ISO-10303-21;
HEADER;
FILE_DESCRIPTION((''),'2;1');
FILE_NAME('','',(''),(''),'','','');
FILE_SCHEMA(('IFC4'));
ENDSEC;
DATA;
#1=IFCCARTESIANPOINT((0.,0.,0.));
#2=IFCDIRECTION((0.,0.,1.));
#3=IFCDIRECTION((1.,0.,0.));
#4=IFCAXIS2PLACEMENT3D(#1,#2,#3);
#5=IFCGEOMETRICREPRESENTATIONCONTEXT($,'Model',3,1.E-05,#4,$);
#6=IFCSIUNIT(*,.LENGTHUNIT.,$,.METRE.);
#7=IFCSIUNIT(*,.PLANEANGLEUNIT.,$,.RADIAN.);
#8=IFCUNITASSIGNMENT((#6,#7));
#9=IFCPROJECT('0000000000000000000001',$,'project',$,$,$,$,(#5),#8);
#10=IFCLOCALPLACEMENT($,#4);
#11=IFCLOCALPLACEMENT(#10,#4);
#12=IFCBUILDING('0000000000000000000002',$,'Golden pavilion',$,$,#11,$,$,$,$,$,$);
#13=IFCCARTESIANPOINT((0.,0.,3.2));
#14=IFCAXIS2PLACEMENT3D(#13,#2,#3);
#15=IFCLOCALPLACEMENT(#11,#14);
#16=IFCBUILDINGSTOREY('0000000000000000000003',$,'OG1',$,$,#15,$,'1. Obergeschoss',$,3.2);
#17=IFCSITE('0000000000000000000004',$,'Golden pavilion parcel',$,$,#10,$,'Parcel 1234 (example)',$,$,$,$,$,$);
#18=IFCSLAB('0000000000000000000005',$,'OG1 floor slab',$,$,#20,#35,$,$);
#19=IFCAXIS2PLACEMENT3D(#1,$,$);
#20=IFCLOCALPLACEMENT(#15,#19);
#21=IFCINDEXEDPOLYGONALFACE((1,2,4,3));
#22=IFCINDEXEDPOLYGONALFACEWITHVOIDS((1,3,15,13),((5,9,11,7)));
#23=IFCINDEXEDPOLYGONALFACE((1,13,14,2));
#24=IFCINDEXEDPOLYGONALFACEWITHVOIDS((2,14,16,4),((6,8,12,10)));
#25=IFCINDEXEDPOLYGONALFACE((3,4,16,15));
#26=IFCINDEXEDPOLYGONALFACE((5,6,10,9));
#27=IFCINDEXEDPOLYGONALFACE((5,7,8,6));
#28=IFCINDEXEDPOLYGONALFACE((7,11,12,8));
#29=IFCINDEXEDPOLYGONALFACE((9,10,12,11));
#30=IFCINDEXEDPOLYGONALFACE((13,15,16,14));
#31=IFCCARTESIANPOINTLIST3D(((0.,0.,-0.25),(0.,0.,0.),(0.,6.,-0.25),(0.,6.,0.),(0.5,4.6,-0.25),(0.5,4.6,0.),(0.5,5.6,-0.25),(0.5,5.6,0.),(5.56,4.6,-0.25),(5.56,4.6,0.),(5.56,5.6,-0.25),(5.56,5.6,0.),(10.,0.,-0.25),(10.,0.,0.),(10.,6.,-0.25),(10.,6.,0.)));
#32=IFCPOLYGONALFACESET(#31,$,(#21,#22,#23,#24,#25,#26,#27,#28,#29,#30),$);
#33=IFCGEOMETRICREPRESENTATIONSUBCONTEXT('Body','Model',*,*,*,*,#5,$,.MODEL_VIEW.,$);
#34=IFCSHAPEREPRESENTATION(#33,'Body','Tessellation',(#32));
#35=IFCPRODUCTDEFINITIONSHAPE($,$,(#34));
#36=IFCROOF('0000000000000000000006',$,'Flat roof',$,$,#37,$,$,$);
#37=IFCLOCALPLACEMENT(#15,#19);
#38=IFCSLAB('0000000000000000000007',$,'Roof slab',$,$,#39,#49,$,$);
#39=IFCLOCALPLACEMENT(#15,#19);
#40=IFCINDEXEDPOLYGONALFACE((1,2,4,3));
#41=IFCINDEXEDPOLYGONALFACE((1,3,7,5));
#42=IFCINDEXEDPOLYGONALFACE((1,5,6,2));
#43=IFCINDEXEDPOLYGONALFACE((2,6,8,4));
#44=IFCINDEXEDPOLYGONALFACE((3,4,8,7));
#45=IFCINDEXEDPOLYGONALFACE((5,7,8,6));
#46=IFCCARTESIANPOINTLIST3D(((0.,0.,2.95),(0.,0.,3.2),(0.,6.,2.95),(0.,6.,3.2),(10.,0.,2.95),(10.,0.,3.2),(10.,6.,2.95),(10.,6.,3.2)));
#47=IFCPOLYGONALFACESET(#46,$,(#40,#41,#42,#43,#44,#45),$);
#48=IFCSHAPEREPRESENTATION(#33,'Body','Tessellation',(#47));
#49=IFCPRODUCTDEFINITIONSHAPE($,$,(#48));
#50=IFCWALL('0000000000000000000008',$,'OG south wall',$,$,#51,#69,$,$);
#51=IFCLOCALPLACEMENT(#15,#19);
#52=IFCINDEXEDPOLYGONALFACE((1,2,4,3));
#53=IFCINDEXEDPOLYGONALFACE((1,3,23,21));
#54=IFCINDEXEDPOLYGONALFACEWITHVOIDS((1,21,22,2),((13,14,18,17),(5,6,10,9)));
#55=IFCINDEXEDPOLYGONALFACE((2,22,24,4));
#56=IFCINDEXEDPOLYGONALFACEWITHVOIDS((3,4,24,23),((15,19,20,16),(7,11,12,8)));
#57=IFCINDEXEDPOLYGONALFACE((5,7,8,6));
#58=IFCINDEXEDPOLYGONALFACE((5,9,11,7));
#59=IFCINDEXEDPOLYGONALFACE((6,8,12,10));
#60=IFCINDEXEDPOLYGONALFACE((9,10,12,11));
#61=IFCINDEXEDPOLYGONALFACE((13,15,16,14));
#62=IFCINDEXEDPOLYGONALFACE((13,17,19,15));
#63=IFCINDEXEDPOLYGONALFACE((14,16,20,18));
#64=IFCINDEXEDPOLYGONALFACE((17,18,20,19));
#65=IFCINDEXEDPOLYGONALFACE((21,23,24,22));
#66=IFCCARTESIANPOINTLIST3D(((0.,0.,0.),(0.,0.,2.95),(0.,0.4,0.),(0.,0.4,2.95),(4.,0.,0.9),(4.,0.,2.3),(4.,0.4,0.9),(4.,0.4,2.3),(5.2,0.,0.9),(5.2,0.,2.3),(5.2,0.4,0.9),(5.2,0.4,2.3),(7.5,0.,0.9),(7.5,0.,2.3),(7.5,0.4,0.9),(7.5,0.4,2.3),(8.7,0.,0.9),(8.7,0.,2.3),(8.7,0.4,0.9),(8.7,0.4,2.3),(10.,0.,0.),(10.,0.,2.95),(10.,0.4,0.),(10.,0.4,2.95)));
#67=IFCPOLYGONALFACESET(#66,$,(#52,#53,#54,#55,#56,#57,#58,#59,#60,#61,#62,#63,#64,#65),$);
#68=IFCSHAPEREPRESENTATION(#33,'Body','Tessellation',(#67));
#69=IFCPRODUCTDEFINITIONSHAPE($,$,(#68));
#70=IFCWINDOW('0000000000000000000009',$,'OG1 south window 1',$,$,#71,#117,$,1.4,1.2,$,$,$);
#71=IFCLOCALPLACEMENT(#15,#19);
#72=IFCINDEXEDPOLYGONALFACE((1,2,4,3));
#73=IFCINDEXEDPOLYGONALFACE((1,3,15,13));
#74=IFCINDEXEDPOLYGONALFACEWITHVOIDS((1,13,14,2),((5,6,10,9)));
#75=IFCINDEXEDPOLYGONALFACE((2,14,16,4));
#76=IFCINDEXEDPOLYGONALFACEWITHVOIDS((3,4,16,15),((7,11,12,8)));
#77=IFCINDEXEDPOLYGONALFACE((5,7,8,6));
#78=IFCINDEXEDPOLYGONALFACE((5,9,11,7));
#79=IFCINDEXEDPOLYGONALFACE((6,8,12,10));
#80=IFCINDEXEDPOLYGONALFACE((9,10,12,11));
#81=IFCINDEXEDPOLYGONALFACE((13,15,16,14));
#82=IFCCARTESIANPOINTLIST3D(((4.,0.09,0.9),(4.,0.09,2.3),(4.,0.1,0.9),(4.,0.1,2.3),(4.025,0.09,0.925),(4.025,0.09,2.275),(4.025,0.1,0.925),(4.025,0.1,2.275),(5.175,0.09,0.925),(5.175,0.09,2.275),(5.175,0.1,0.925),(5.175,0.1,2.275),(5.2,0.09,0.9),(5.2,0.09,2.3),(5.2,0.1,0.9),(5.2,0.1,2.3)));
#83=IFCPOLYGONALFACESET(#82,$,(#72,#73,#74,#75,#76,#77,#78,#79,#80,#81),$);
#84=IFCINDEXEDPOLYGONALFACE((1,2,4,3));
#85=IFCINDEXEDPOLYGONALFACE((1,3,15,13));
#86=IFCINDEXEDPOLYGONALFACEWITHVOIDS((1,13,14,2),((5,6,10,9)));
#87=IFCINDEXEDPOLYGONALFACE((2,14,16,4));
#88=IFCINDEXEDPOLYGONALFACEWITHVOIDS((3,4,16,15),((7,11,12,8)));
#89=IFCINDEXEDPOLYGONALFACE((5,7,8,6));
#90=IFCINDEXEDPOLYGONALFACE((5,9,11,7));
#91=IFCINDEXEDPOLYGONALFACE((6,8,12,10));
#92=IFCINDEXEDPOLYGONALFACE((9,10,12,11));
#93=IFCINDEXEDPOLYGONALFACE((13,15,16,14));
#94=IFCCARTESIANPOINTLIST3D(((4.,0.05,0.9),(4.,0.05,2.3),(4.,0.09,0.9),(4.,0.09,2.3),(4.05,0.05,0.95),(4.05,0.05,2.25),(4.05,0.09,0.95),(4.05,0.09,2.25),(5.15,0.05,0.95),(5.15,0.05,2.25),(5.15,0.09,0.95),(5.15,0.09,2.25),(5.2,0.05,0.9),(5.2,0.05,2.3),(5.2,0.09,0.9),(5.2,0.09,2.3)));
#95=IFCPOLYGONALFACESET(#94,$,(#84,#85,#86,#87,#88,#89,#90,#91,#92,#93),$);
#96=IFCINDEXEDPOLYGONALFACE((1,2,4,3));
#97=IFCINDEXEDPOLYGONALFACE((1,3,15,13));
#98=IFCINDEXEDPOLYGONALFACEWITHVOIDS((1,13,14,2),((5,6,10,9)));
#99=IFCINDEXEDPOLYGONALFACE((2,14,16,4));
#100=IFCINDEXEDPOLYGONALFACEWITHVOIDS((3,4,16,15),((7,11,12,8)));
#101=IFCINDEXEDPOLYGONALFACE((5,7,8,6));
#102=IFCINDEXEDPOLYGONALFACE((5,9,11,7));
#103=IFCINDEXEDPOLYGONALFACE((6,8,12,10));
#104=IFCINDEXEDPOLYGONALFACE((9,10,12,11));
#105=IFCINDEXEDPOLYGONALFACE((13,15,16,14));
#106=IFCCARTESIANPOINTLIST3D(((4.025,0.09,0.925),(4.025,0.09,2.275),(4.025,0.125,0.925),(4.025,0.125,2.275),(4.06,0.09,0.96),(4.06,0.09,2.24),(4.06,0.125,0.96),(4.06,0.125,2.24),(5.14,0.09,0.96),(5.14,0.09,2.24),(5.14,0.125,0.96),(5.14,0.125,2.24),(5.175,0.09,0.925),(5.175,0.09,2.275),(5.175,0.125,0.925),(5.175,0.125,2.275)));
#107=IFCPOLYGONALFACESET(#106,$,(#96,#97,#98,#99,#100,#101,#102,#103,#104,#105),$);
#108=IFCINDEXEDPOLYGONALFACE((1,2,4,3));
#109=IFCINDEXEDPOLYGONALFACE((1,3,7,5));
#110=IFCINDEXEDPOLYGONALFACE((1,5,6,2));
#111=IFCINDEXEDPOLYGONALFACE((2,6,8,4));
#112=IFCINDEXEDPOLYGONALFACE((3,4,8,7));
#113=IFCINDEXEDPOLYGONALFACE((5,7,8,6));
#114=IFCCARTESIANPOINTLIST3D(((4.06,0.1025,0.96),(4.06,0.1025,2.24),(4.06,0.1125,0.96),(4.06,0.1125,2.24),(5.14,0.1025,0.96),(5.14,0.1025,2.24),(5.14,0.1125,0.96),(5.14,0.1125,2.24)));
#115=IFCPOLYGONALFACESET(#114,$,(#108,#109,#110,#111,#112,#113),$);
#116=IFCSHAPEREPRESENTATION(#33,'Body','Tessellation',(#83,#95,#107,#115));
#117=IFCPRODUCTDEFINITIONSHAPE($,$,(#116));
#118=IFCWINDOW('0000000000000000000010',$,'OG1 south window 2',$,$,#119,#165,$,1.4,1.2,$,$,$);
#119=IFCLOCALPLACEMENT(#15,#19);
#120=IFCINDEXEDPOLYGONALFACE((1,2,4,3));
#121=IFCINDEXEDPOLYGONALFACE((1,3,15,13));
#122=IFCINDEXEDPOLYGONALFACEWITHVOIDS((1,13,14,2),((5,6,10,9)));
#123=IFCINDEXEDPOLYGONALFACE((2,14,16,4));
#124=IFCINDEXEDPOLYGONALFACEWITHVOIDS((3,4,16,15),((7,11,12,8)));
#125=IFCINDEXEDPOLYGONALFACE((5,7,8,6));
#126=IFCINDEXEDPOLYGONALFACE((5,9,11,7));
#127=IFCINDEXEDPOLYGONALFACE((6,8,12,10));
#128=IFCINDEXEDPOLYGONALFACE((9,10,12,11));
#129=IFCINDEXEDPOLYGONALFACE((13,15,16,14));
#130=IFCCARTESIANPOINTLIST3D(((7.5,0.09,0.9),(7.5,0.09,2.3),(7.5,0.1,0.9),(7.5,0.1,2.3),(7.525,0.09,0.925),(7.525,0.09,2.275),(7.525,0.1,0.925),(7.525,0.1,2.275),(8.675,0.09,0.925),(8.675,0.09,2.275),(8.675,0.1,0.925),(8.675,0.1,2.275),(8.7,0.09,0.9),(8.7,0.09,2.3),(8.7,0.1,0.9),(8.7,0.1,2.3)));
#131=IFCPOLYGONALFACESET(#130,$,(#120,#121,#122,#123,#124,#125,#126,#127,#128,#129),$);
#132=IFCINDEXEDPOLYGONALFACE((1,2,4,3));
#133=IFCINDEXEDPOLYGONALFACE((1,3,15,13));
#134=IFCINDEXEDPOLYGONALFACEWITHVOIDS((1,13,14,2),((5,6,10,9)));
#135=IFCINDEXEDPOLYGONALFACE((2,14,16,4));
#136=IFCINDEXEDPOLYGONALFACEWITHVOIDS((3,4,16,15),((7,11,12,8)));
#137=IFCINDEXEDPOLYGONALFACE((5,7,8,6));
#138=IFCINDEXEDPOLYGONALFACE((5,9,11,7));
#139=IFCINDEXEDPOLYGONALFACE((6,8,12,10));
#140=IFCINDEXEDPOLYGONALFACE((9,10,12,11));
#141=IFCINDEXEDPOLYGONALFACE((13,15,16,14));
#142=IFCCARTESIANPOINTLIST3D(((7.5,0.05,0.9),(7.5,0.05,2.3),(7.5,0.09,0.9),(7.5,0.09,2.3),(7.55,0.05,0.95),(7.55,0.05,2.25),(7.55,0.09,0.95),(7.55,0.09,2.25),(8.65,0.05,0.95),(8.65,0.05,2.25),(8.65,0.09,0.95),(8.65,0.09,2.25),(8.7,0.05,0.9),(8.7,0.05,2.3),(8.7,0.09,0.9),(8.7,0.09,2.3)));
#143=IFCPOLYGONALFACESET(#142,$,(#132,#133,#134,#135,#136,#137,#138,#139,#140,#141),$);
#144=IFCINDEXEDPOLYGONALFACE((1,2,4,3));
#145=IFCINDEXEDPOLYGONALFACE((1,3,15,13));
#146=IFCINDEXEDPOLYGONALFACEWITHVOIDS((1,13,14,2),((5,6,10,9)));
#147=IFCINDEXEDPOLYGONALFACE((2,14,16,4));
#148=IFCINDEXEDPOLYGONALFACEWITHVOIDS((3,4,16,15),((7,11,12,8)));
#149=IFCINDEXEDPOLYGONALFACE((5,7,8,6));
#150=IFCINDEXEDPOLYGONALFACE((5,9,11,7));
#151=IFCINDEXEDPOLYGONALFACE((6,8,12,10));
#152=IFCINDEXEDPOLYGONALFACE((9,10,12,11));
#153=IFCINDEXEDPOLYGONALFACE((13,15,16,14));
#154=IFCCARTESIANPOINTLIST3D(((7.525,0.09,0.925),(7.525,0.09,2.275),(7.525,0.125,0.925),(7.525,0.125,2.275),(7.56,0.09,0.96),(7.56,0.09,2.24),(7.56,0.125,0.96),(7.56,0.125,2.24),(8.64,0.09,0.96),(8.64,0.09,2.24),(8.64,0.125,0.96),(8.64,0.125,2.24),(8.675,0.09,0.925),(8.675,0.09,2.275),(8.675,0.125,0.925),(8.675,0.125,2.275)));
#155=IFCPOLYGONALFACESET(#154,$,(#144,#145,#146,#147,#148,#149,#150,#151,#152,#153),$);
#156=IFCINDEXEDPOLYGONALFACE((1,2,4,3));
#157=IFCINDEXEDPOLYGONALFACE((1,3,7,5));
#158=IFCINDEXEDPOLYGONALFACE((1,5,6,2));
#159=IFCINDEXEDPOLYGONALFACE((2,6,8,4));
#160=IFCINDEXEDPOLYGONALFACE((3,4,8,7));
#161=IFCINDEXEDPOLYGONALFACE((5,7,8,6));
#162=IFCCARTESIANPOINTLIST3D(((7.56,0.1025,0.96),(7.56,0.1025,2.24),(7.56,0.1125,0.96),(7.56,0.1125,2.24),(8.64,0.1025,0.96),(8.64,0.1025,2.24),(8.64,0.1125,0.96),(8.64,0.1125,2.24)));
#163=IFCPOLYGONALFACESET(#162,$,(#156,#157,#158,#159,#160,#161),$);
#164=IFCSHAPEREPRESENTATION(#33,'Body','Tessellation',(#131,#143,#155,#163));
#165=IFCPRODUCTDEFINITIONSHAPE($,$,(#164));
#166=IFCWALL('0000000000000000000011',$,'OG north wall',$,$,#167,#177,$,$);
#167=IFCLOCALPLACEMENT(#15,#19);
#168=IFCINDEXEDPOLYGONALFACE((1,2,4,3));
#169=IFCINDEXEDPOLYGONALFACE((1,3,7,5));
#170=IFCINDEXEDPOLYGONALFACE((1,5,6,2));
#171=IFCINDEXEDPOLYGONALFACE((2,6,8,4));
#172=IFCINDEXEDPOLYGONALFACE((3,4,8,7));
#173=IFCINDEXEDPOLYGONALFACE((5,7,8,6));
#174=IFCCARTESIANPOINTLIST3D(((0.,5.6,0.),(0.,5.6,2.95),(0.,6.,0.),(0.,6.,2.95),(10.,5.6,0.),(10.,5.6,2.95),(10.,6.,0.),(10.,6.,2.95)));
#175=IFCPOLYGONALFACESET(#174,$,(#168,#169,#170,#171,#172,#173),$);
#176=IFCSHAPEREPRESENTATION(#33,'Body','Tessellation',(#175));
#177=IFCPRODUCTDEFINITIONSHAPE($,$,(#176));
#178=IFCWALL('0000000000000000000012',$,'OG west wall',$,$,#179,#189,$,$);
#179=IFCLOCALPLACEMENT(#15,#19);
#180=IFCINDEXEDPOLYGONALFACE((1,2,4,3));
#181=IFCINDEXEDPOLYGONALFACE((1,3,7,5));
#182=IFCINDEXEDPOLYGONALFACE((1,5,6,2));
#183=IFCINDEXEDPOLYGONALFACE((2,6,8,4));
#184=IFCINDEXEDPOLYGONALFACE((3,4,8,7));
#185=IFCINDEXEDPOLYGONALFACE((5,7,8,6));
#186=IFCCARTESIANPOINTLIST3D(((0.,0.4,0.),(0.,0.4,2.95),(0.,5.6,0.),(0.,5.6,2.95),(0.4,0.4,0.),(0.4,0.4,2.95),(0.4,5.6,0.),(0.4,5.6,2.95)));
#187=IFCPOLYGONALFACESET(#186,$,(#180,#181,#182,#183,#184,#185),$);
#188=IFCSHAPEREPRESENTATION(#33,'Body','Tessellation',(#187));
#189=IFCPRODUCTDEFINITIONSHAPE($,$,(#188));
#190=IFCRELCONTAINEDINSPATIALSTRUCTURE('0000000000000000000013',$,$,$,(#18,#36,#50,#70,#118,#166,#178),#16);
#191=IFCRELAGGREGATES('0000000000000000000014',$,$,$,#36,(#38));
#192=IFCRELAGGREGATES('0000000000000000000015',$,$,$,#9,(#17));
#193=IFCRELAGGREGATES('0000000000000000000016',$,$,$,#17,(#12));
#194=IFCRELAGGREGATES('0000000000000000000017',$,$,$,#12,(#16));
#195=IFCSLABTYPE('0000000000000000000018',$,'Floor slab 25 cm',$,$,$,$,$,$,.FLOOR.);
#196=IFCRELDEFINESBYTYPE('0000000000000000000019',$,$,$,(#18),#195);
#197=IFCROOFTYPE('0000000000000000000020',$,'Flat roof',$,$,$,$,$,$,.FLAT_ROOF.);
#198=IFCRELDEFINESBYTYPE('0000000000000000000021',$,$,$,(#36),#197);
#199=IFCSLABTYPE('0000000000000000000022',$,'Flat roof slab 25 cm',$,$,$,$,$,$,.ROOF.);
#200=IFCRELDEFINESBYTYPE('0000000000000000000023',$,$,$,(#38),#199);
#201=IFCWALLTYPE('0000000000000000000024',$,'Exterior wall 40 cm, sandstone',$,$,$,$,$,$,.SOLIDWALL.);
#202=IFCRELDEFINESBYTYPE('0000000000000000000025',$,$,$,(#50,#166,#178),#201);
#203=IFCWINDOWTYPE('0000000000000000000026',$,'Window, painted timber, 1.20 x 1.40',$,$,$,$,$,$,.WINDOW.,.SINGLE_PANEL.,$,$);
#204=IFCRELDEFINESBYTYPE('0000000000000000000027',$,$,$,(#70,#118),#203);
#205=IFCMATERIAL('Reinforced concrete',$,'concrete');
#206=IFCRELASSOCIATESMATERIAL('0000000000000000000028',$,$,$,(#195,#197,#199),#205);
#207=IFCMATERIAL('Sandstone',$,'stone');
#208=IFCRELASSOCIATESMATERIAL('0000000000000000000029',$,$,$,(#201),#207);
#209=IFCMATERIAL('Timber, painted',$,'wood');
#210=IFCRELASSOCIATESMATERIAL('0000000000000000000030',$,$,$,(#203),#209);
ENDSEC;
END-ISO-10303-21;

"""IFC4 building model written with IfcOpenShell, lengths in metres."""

from ifc_helpers import new_model, si_unit, frame, origin_with_axes, place, context, subcontext, project, spatial, line, indexed_curve, outline, extrude, source, transform, mapped, material, type_object, type_shapes, element, fill, aggregate, save


model = new_model("IFC4")

# Units and contexts
model_context = context("Model", 3, precision=1e-05, world=origin_with_axes())
body_context = subcontext(model_context, "Body", "Model", "MODEL_VIEW")
ifc_project = project(units=[si_unit("LENGTHUNIT", "METRE"), si_unit("PLANEANGLEUNIT", "RADIAN")], contexts=[model_context])

# Site, building, storey
site_placement = place(None, origin_with_axes())
site = spatial("IfcSite", under=ifc_project, at=site_placement, Name="Golden pavilion parcel", LongName="Parcel 1234 (example)")
building_placement = place(site_placement, origin_with_axes())
building = spatial("IfcBuilding", under=site, at=building_placement, Name="Golden pavilion")
storey_placement = place(building_placement, frame((0.0, 0.0, 3.2), z_axis=(0.0, 0.0, 1.0), x_axis=(1.0, 0.0, 0.0)))
storey = spatial("IfcBuildingStorey", under=building, at=storey_placement, Name="OG1", LongName="1. Obergeschoss", Elevation=3.2)

# Slab
ifc_material_1 = material(Name="Reinforced concrete", Category="concrete")
slab_type_1 = type_object("IfcSlabType", Name="Floor slab 25 cm", PredefinedType="FLOOR", material=ifc_material_1)
slab_1_placement = place(storey_placement, frame((0.0, 0.0, -0.25), z_axis=(0.0, 0.0, 1.0), x_axis=(1.0, 0.0, 0.0)))
element("IfcSlab", 1, at=slab_1_placement, inside=storey, type_object=slab_type_1, Name="OG1 floor slab", context=body_context, shape_type="SweptSolid", body=[
    extrude(outline(indexed_curve([(0.0, 0.0), (10.0, 0.0), (10.0, 6.0), (0.0, 6.0)], segments=[line(1, 2, 3, 4, 1)]), holes=[indexed_curve([(0.5, 4.6), (5.56, 4.6), (5.56, 5.6), (0.5, 5.6)], segments=[line(1, 2, 3, 4, 1)])]), origin_with_axes(), (0.0, 0.0, 1.0), 0.25),
])

# Roof, slab
roof_type = type_object("IfcRoofType", Name="Flat roof", PredefinedType="FLAT_ROOF", material=ifc_material_1)
roof_placement = place(storey_placement, frame((0.0, 0.0, 2.95), z_axis=(0.0, 0.0, 1.0), x_axis=(1.0, 0.0, 0.0)))
roof = element("IfcRoof", 2, at=roof_placement, inside=storey, type_object=roof_type, Name="Flat roof")
slab_type_2 = type_object("IfcSlabType", Name="Flat roof slab 25 cm", PredefinedType="ROOF", material=ifc_material_1)
slab_2_placement = place(roof_placement, origin_with_axes())
slab_2 = element("IfcSlab", 3, at=slab_2_placement, type_object=slab_type_2, Name="Roof slab", context=body_context, shape_type="SweptSolid", body=[
    extrude(outline(indexed_curve([(0.0, 0.0), (10.0, 0.0), (10.0, 6.0), (0.0, 6.0)], segments=[line(1, 2, 3, 4, 1)])), origin_with_axes(), (0.0, 0.0, 1.0), 0.25),
])
aggregate(roof, [slab_2])

# Wall, openings, windows
ifc_material_2 = material(Name="Sandstone", Category="stone")
wall_type = type_object("IfcWallType", Name="Exterior wall 40 cm, sandstone", PredefinedType="SOLIDWALL", material=ifc_material_2)
wall_1_placement = place(storey_placement, origin_with_axes())
wall_1 = element("IfcWall", 4, at=wall_1_placement, inside=storey, type_object=wall_type, Name="OG south wall", context=body_context, shape_type="SweptSolid", body=[
    extrude(outline(indexed_curve([(0.0, 0.0), (0.0, 0.4), (10.0, 0.4), (10.0, 0.0), (0.0, 0.0)], self_intersect=False)), origin_with_axes(), (0.0, 0.0, 1.0), 2.95),
])
opening_1_placement = place(wall_1_placement, origin_with_axes())
opening_1 = element("IfcOpeningElement", 5, at=opening_1_placement, cuts=wall_1, PredefinedType="OPENING", context=body_context, shape_type="SweptSolid", body=[
    extrude(outline(indexed_curve([(4.0, -0.05), (5.2, -0.05), (5.2, 0.45), (4.0, 0.45)], segments=[line(1, 2, 3, 4, 1)])), frame((0.0, 0.0, 0.9), z_axis=(0.0, 0.0, 1.0), x_axis=(1.0, 0.0, 0.0)), (0.0, 0.0, 1.0), 1.4),
])
opening_2_placement = place(wall_1_placement, origin_with_axes())
opening_2 = element("IfcOpeningElement", 6, at=opening_2_placement, cuts=wall_1, PredefinedType="OPENING", context=body_context, shape_type="SweptSolid", body=[
    extrude(outline(indexed_curve([(7.5, -0.05), (8.7, -0.05), (8.7, 0.45), (7.5, 0.45)], segments=[line(1, 2, 3, 4, 1)])), frame((0.0, 0.0, 0.9), z_axis=(0.0, 0.0, 1.0), x_axis=(1.0, 0.0, 0.0)), (0.0, 0.0, 1.0), 1.4),
])
ifc_material_3 = material(Name="Timber, painted", Category="wood")
window_type = type_object("IfcWindowType", Name="Window, painted timber, 1.20 x 1.40", PartitioningType="SINGLE_PANEL", PredefinedType="WINDOW", material=ifc_material_3)
shared_shape = source(origin_with_axes(), body_context, "Body", "SweptSolid", [
    extrude(outline(indexed_curve([(0.0, 0.0), (1.2, 0.0), (1.2, 1.4), (0.0, 1.4)], segments=[line(1, 2, 3, 4, 1)]), holes=[indexed_curve([(0.025, 0.025), (1.175, 0.025), (1.175, 1.375), (0.025, 1.375)], segments=[line(1, 2, 3, 4, 1)])]), frame((0.0, 0.09, 0.0), z_axis=(0.0, -1.0, 0.0), x_axis=(1.0, 0.0, 0.0)), (0.0, 0.0, -1.0), 0.01),
    extrude(outline(indexed_curve([(0.0, 0.0), (1.2, 0.0), (1.2, 1.4), (0.0, 1.4)], segments=[line(1, 2, 3, 4, 1)]), holes=[indexed_curve([(0.05, 0.05), (1.15, 0.05), (1.15, 1.35), (0.05, 1.35)], segments=[line(1, 2, 3, 4, 1)])]), frame((0.0, 0.05, 0.0), z_axis=(0.0, -1.0, 0.0), x_axis=(1.0, 0.0, 0.0)), (0.0, 0.0, -1.0), 0.04),
    extrude(outline(indexed_curve([(0.0, 0.0), (1.15, 0.0), (1.15, 1.35), (0.0, 1.35)], segments=[line(1, 2, 3, 4, 1)]), holes=[indexed_curve([(0.035, 0.035), (1.115, 0.035), (1.115, 1.315), (0.035, 1.315)], segments=[line(1, 2, 3, 4, 1)])]), frame((0.025, 0.09, 0.025), z_axis=(0.0, -1.0, 0.0), x_axis=(1.0, 0.0, 0.0)), (0.0, 0.0, -1.0), 0.035),
    extrude(outline(indexed_curve([(0.035, 0.035), (1.115, 0.035), (1.115, 1.315), (0.035, 1.315)], segments=[line(1, 2, 3, 4, 1)])), frame((0.025, 0.1025, 0.025), z_axis=(0.0, -1.0, 0.0), x_axis=(1.0, 0.0, 0.0)), (0.0, 0.0, -1.0), 0.01),
])
type_shapes(window_type, [shared_shape])
window_1_placement = place(storey_placement, frame((4.0, 0.0, 0.9), z_axis=(0.0, 0.0, 1.0), x_axis=(1.0, 0.0, 0.0)))
window_1 = element("IfcWindow", 7, at=window_1_placement, inside=storey, type_object=window_type, Name="OG1 south window 1", OverallHeight=1.4, OverallWidth=1.2, context=body_context, shape_type="MappedRepresentation", body=[
    mapped(shared_shape, transform((0.0, 0.0, 0.0), x_axis=(1.0, 0.0, 0.0), y_axis=(0.0, 1.0, 0.0), z_axis=(0.0, 0.0, 1.0), scale=1.0)),
])
fill(opening_1, window_1)
window_2_placement = place(storey_placement, frame((7.5, 0.0, 0.9), z_axis=(0.0, 0.0, 1.0), x_axis=(1.0, 0.0, 0.0)))
window_2 = element("IfcWindow", 8, at=window_2_placement, inside=storey, type_object=window_type, Name="OG1 south window 2", OverallHeight=1.4, OverallWidth=1.2, context=body_context, shape_type="MappedRepresentation", body=[
    mapped(shared_shape, transform((0.0, 0.0, 0.0), x_axis=(1.0, 0.0, 0.0), y_axis=(0.0, 1.0, 0.0), z_axis=(0.0, 0.0, 1.0), scale=1.0)),
])
fill(opening_2, window_2)

# Walls
wall_2_placement = place(storey_placement, frame((10.0, 6.0, 0.0), z_axis=(0.0, 0.0, 1.0), x_axis=(-1.0, 0.0, 0.0)))
element("IfcWall", 9, at=wall_2_placement, inside=storey, type_object=wall_type, Name="OG north wall", context=body_context, shape_type="SweptSolid", body=[
    extrude(outline(indexed_curve([(0.0, 0.0), (0.0, 0.4), (10.0, 0.4), (10.0, 0.0), (0.0, 0.0)], self_intersect=False)), origin_with_axes(), (0.0, 0.0, 1.0), 2.95),
])
for number, where, z_axis, x_axis, name in (
    (10, (0.0, 5.6, 0.0), (0.0, 0.0, 1.0), (0.0, -1.0, 0.0), "OG west wall"),
):
    element("IfcWall", number, at=place(storey_placement, frame(where, z_axis=z_axis, x_axis=x_axis)), inside=storey, type_object=wall_type, Name=name, context=body_context, shape_type="SweptSolid", body=[
        extrude(outline(indexed_curve([(0.0, 0.0), (0.0, 0.4), (5.2, 0.4), (5.2, 0.0), (0.0, 0.0)], self_intersect=False)), origin_with_axes(), (0.0, 0.0, 1.0), 2.95),
    ])

save(model, "model.ifc")
